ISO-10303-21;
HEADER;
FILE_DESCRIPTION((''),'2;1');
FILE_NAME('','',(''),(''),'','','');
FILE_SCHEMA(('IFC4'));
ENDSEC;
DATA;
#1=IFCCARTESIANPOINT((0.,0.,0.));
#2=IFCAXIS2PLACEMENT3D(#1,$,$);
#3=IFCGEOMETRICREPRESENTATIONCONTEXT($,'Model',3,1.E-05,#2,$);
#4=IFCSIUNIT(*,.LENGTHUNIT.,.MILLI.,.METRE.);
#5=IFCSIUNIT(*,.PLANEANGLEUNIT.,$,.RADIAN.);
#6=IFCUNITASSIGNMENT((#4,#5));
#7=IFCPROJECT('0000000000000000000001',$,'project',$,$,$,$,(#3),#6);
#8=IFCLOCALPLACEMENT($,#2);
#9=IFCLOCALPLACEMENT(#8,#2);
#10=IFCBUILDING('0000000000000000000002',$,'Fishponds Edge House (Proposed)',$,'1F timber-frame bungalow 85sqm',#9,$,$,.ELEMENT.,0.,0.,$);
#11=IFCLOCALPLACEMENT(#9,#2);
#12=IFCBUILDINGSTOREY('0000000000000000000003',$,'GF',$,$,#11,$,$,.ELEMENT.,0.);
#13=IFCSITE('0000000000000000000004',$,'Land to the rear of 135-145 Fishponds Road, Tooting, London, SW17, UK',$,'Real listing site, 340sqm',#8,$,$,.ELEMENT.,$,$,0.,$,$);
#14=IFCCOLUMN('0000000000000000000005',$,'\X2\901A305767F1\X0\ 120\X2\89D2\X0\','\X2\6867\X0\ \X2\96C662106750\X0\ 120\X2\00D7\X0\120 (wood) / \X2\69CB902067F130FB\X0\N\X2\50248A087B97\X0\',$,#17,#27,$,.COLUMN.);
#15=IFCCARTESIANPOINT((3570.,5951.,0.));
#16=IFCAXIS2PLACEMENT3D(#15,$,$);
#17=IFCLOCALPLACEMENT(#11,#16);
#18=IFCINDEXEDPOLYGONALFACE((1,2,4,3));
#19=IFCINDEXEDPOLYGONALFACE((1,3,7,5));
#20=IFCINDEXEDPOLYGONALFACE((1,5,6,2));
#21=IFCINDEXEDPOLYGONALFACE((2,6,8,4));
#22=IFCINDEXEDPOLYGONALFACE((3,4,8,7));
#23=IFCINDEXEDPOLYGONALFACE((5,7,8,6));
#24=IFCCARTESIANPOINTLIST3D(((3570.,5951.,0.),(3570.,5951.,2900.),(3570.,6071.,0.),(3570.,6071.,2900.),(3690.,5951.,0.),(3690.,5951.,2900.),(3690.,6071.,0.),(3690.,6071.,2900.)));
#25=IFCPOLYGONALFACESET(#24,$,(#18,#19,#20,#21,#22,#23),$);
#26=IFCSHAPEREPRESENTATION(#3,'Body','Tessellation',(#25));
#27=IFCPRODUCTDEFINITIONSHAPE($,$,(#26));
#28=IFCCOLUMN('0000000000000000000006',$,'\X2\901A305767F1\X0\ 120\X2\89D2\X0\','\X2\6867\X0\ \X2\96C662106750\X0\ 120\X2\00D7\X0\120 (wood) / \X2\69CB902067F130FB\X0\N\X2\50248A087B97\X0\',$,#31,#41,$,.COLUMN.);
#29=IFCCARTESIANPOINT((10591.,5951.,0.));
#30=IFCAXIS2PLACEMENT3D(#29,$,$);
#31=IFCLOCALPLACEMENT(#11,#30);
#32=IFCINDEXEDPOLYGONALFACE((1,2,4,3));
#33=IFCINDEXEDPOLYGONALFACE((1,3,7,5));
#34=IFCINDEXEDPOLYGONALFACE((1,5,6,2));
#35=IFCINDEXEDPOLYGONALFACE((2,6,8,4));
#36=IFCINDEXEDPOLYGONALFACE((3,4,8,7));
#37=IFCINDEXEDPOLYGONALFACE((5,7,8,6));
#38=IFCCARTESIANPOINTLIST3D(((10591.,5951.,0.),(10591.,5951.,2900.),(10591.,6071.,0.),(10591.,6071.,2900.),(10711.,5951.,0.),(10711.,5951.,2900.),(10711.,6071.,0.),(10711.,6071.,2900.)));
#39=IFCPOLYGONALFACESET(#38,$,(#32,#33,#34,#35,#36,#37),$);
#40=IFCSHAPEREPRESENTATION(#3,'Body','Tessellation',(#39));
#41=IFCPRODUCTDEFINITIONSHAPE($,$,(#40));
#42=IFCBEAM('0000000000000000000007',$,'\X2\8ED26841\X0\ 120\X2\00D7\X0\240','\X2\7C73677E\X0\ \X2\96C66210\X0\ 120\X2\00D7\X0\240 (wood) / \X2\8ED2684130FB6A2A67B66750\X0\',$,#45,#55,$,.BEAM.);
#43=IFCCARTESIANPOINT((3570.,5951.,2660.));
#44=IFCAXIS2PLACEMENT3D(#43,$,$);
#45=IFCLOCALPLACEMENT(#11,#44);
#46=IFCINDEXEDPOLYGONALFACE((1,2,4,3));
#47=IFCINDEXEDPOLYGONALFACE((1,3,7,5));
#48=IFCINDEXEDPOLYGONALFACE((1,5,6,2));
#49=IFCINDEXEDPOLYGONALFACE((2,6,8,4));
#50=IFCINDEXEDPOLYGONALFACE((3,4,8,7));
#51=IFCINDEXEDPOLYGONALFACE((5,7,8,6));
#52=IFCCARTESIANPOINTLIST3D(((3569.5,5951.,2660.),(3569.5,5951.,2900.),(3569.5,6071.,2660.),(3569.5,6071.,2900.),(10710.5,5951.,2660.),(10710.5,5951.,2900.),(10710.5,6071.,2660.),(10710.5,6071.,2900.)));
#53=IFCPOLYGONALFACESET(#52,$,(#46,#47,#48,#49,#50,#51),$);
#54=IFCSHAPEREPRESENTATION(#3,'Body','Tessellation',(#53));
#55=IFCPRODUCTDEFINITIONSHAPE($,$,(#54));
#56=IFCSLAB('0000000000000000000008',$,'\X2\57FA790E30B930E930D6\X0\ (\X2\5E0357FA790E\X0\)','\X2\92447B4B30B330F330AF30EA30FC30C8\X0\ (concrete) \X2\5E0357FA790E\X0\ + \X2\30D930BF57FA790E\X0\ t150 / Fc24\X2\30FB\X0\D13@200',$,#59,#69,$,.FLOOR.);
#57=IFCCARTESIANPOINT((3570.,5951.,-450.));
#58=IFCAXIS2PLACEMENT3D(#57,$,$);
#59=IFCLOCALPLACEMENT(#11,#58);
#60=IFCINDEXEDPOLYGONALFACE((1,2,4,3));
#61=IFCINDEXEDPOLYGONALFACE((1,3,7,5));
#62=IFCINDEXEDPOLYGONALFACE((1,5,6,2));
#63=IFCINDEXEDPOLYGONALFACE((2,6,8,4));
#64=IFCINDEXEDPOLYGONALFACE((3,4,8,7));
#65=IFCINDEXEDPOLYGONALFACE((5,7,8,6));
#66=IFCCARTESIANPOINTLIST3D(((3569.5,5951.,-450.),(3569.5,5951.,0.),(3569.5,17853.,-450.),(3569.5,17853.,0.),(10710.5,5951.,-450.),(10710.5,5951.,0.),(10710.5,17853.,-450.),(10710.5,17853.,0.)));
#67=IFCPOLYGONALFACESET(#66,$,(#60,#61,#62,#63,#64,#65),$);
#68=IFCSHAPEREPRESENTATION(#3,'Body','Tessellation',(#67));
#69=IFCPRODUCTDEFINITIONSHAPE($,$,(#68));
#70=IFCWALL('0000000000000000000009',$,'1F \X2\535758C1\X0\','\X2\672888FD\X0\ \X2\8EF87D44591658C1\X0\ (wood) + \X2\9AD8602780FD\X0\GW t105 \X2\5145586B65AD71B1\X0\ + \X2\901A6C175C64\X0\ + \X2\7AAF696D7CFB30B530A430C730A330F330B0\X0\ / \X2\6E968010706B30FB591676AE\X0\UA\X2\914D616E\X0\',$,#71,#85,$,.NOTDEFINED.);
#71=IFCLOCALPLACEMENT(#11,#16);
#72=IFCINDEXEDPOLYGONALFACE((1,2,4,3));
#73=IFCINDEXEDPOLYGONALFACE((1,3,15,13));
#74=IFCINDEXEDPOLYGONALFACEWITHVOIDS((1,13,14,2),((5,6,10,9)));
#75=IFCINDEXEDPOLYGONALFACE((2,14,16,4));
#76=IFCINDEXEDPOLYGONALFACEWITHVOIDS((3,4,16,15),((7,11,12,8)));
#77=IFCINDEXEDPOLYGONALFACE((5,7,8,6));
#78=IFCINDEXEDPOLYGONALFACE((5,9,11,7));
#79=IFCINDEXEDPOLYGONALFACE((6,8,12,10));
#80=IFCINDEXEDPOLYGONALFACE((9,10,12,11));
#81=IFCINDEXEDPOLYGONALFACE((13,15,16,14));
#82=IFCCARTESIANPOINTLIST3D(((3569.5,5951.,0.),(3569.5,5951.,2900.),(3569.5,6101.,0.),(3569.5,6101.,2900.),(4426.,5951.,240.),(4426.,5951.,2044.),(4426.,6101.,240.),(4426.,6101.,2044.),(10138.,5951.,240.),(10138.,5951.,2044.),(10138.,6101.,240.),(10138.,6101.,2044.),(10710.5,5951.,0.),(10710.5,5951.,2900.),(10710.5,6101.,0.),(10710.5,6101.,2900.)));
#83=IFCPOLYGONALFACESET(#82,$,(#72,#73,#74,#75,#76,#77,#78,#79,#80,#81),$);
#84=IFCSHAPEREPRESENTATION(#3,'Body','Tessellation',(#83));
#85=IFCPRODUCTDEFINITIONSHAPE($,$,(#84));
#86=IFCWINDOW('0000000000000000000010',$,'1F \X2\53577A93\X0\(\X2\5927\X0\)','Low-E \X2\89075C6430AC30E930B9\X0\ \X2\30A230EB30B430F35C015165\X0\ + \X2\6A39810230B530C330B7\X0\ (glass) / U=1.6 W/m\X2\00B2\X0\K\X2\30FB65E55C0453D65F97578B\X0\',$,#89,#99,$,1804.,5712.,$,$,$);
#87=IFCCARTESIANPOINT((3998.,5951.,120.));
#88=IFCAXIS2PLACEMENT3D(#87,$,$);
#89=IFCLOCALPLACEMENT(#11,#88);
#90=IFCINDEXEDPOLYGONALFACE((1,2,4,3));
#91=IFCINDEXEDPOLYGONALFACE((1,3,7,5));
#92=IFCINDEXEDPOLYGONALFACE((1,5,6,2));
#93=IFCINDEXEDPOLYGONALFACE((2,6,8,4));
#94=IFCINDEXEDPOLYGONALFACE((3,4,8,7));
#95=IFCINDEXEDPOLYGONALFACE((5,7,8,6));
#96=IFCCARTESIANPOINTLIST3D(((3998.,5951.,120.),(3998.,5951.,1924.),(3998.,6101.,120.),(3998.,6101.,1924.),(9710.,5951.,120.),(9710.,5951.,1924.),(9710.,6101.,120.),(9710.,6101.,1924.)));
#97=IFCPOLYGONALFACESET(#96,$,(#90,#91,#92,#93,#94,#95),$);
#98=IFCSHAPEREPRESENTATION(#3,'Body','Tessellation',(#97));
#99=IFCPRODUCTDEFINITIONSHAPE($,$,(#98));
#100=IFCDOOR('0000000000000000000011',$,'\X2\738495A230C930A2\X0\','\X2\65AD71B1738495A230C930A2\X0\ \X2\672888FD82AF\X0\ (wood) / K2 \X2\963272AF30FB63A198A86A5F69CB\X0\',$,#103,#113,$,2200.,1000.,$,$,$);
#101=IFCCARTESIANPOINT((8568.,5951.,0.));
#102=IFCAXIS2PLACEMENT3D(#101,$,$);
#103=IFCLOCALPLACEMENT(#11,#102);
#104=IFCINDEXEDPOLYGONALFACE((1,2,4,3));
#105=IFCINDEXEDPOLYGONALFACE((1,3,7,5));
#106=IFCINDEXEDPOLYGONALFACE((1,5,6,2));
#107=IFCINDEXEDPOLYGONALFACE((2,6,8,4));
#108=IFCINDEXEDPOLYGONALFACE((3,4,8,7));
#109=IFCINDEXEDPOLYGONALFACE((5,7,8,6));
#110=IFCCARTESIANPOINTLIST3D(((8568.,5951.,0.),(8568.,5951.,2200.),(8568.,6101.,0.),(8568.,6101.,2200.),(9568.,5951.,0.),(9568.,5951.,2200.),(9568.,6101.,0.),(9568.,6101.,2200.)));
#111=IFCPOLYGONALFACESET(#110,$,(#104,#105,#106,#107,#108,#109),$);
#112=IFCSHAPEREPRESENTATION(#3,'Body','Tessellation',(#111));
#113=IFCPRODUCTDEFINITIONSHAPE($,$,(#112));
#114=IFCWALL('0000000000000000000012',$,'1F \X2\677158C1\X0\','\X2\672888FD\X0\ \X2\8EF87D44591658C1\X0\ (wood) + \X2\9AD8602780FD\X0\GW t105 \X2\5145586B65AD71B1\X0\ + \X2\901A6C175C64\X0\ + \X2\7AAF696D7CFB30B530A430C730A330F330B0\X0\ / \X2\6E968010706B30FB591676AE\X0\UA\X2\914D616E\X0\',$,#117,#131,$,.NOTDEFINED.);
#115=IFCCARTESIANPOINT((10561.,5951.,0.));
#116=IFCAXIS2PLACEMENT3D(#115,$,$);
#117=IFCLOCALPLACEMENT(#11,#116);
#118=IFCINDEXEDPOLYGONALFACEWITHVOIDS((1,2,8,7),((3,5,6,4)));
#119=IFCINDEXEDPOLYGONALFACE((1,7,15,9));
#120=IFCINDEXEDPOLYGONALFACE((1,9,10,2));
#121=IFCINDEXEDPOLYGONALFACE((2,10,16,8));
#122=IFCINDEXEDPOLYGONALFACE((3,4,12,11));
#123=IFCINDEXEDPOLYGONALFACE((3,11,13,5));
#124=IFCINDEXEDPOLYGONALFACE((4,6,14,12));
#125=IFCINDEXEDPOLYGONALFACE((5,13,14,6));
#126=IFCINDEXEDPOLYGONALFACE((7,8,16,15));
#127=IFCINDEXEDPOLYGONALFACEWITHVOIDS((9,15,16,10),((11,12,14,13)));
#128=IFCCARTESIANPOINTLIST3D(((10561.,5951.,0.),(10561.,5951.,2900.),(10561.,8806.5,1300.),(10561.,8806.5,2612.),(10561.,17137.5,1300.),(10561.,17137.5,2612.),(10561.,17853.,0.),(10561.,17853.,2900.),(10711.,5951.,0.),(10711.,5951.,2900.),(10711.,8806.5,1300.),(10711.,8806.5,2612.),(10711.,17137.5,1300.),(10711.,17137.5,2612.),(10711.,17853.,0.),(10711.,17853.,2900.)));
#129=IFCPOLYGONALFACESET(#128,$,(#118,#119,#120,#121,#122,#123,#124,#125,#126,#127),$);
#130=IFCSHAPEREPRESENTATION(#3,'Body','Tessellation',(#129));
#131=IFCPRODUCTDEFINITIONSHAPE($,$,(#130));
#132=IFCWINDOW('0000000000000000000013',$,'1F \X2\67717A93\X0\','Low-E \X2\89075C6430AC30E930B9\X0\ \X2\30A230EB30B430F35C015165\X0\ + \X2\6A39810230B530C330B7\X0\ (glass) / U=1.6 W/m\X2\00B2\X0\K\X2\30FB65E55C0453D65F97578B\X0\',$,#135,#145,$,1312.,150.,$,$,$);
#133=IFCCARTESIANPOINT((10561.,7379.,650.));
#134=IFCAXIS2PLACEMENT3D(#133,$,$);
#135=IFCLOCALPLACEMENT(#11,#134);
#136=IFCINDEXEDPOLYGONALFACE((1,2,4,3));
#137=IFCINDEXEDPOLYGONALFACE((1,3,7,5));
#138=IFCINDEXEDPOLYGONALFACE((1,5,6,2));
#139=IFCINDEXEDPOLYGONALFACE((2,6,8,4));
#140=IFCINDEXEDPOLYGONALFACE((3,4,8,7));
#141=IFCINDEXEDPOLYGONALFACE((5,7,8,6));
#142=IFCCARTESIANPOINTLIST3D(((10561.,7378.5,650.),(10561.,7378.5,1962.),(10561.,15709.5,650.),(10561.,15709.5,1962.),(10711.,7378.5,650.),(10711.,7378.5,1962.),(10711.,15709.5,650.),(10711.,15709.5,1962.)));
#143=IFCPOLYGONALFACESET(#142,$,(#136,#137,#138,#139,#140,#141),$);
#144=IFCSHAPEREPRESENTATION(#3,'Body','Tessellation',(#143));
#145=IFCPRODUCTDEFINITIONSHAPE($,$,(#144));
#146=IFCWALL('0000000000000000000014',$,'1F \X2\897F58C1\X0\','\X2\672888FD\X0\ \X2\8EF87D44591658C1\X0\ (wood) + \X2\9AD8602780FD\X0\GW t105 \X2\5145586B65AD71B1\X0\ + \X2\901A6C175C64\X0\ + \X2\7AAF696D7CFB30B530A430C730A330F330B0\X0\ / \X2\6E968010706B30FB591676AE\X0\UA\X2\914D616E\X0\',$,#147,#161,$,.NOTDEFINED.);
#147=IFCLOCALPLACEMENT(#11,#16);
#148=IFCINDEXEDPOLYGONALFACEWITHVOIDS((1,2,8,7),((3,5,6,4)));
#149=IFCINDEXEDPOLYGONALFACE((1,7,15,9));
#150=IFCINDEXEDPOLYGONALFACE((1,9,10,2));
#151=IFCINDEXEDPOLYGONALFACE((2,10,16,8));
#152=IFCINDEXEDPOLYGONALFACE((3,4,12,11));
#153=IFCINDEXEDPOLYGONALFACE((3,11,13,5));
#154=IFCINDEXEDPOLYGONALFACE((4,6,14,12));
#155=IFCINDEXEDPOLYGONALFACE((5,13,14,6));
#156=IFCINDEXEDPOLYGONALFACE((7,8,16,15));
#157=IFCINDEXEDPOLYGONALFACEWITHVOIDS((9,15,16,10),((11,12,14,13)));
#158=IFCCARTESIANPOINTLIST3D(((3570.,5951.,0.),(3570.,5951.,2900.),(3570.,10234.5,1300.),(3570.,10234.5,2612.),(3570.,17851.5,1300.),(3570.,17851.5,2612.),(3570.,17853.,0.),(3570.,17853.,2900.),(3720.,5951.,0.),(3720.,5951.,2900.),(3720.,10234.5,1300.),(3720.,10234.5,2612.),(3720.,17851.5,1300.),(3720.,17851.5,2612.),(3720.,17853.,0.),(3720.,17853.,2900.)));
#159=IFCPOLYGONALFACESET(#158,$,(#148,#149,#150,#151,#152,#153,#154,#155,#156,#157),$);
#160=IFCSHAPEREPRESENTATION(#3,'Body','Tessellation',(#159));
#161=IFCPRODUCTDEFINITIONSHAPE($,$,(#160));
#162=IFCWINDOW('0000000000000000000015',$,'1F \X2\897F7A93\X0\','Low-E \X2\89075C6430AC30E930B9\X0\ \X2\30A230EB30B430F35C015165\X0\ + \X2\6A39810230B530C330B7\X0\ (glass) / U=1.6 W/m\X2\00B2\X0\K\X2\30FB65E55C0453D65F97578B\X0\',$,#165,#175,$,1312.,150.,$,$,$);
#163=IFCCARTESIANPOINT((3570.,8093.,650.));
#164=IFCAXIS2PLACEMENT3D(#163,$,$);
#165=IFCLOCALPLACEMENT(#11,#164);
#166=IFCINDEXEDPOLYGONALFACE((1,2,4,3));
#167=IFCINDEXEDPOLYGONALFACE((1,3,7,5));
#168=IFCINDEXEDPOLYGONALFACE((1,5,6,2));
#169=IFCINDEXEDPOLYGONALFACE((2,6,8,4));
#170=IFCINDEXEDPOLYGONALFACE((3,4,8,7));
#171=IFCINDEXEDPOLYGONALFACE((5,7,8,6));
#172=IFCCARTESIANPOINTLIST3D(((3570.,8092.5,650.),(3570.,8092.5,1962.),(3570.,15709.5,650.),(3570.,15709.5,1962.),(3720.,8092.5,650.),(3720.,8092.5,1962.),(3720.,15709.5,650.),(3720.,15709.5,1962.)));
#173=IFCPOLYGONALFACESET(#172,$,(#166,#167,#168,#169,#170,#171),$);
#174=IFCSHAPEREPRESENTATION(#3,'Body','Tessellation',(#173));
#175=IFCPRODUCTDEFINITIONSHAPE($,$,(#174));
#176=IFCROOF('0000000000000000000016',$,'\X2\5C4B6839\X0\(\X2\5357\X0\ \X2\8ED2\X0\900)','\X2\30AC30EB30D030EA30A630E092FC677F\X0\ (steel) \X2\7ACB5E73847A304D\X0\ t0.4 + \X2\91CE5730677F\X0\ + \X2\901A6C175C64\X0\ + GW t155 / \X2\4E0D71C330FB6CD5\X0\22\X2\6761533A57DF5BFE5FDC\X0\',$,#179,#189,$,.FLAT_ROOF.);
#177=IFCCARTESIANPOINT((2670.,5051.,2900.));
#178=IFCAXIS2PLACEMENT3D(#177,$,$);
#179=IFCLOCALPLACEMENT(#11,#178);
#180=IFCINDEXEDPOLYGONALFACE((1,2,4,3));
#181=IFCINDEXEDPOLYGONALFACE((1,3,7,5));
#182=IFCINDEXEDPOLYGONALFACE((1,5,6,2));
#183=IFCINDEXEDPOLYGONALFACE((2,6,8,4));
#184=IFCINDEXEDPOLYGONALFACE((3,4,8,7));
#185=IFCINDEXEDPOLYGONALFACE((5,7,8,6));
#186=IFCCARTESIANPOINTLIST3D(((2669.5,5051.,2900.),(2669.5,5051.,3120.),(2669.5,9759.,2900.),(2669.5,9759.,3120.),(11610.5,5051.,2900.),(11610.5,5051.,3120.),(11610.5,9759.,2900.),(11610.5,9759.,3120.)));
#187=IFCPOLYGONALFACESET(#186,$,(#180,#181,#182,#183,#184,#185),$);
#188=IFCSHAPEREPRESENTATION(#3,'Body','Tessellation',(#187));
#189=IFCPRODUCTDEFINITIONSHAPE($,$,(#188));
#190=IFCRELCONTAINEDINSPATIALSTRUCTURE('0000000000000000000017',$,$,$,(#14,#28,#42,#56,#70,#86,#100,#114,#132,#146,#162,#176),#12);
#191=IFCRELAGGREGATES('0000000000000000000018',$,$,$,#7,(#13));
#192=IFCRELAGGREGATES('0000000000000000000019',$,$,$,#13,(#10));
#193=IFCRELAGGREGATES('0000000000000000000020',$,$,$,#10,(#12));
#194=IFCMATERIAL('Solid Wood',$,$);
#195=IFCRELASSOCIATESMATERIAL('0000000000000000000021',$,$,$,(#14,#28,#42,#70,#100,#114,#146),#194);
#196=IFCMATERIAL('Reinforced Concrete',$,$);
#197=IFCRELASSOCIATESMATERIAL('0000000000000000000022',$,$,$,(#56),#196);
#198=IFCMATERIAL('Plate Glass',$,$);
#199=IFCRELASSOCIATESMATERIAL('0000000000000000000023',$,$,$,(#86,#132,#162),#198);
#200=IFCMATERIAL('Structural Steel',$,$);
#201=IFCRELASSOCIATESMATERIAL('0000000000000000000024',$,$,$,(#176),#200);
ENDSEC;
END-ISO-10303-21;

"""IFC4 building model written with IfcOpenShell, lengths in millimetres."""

from ifc_helpers import new_model, si_unit, frame, frame_2d, origin, place, context, project, spatial, rectangle, extrude, material, element, fill, save


model = new_model("IFC4")

# Units and contexts
model_context = context("Model", 3, precision=1e-05, world=origin())
ifc_project = project(units=[si_unit("LENGTHUNIT", "METRE", prefix="MILLI"), si_unit("PLANEANGLEUNIT", "RADIAN")], contexts=[model_context])

# Site, building, storey
site_placement = place(None, origin())
site = spatial("IfcSite", under=ifc_project, at=site_placement, Name="Land to the rear of 135-145 Fishponds Road, Tooting, London, SW17, UK", ObjectType="Real listing site, 340sqm", CompositionType="ELEMENT", RefElevation=0.0)
building_placement = place(site_placement, origin())
building = spatial("IfcBuilding", under=site, at=building_placement, Name="Fishponds Edge House (Proposed)", ObjectType="1F timber-frame bungalow 85sqm", CompositionType="ELEMENT", ElevationOfRefHeight=0.0, ElevationOfTerrain=0.0)
storey_placement = place(building_placement, origin())
storey = spatial("IfcBuildingStorey", under=building, at=storey_placement, Name="GF", CompositionType="ELEMENT", Elevation=0.0)

# Columns
ifc_material_1 = material(Name="Solid Wood")
column_1_placement = place(storey_placement, frame((3570.0, 5951.0, 0.0)))
element("IfcColumn", 1, at=column_1_placement, inside=storey, material=ifc_material_1, Name="通し柱 120角", Description="桧 集成材 120×120 (wood) / 構造柱・N値計算", PredefinedType="COLUMN", context=model_context, shape_type="SweptSolid", body=[
    extrude(rectangle(XDim=120.0, YDim=120.0, at=frame_2d((60.0, 60.0))), frame((3570.0, 5951.0, 0.0)), (0.0, 0.0, 1.0), 2900.0),
])
column_2_placement = place(storey_placement, frame((10591.0, 5951.0, 0.0)))
element("IfcColumn", 2, at=column_2_placement, inside=storey, material=ifc_material_1, Name="通し柱 120角", Description="桧 集成材 120×120 (wood) / 構造柱・N値計算", PredefinedType="COLUMN", context=model_context, shape_type="SweptSolid", body=[
    extrude(rectangle(XDim=120.0, YDim=120.0, at=frame_2d((60.0, 60.0))), frame((10591.0, 5951.0, 0.0)), (0.0, 0.0, 1.0), 2900.0),
])

# Beam
beam_1_placement = place(storey_placement, frame((3570.0, 5951.0, 2660.0)))
element("IfcBeam", 3, at=beam_1_placement, inside=storey, material=ifc_material_1, Name="軒桁 120×240", Description="米松 集成 120×240 (wood) / 軒桁・横架材", PredefinedType="BEAM", context=model_context, shape_type="SweptSolid", body=[
    extrude(rectangle(XDim=7141.0, YDim=120.0, at=frame_2d((3570.0, 60.0))), frame((3570.0, 5951.0, 2660.0)), (0.0, 0.0, 1.0), 240.0),
])

# Slab
ifc_material_2 = material(Name="Reinforced Concrete")
slab_1_placement = place(storey_placement, frame((3570.0, 5951.0, -450.0)))
element("IfcSlab", 4, at=slab_1_placement, inside=storey, material=ifc_material_2, Name="基礎スラブ (布基礎)", Description="鉄筋コンクリート (concrete) 布基礎 + ベタ基礎 t150 / Fc24・D13@200", PredefinedType="FLOOR", context=model_context, shape_type="SweptSolid", body=[
    extrude(rectangle(XDim=7141.0, YDim=11902.0, at=frame_2d((3570.0, 5951.0))), frame((3570.0, 5951.0, -450.0)), (0.0, 0.0, 1.0), 450.0),
])

# Wall, openings, window, door
wall_1_placement = place(storey_placement, frame((3570.0, 5951.0, 0.0)))
wall_1 = element("IfcWall", 5, at=wall_1_placement, inside=storey, material=ifc_material_1, Name="1F 南壁", Description="木製 軸組外壁 (wood) + 高性能GW t105 充填断熱 + 通気層 + 窯業系サイディング / 準耐火・外皮UA配慮", PredefinedType="NOTDEFINED", context=model_context, shape_type="SweptSolid", body=[
    extrude(rectangle(XDim=7141.0, YDim=150.0, at=frame_2d((3570.0, 75.0))), frame((3570.0, 5951.0, 0.0)), (0.0, 0.0, 1.0), 2900.0),
])
opening_1_placement = place(storey_placement, frame((3998.0, 5951.0, 120.0)))
opening_1 = element("IfcOpeningElement", 6, at=opening_1_placement, cuts=wall_1, PredefinedType="NOTDEFINED", context=model_context, shape_type="SweptSolid", body=[
    extrude(rectangle(XDim=5712.0, YDim=150.0, at=frame_2d((2856.0, 75.0))), frame((3998.0, 5951.0, 120.0)), (0.0, 0.0, 1.0), 1804.0),
])
opening_2_placement = place(storey_placement, frame((8568.0, 5951.0, 0.0)))
opening_2 = element("IfcOpeningElement", 7, at=opening_2_placement, cuts=wall_1, PredefinedType="NOTDEFINED", context=model_context, shape_type="SweptSolid", body=[
    extrude(rectangle(XDim=1000.0, YDim=150.0, at=frame_2d((500.0, 75.0))), frame((8568.0, 5951.0, 0.0)), (0.0, 0.0, 1.0), 2200.0),
])
ifc_material_3 = material(Name="Plate Glass")
window_1_placement = place(storey_placement, frame((3998.0, 5951.0, 120.0)))
window_1 = element("IfcWindow", 8, at=window_1_placement, inside=storey, material=ifc_material_3, Name="1F 南窓(大)", Description="Low-E 複層ガラス アルゴン封入 + 樹脂サッシ (glass) / U=1.6 W/m²K・日射取得型", OverallHeight=1804.0, OverallWidth=5712.0, context=model_context, shape_type="SweptSolid", body=[
    extrude(rectangle(XDim=5712.0, YDim=150.0, at=frame_2d((2856.0, 75.0))), frame((3998.0, 5951.0, 120.0)), (0.0, 0.0, 1.0), 1804.0),
])
fill(opening_1, window_1)
door_placement = place(storey_placement, frame((8568.0, 5951.0, 0.0)))
door = element("IfcDoor", 9, at=door_placement, inside=storey, material=ifc_material_1, Name="玄関ドア", Description="断熱玄関ドア 木製芯 (wood) / K2 防犯・採風機構", OverallHeight=2200.0, OverallWidth=1000.0, context=model_context, shape_type="SweptSolid", body=[
    extrude(rectangle(XDim=1000.0, YDim=150.0, at=frame_2d((500.0, 75.0))), frame((8568.0, 5951.0, 0.0)), (0.0, 0.0, 1.0), 2200.0),
])
fill(opening_2, door)

# Walls, openings, windows
wall_2_placement = place(storey_placement, frame((10561.0, 5951.0, 0.0)))
wall_2 = element("IfcWall", 10, at=wall_2_placement, inside=storey, material=ifc_material_1, Name="1F 東壁", Description="木製 軸組外壁 (wood) + 高性能GW t105 充填断熱 + 通気層 + 窯業系サイディング / 準耐火・外皮UA配慮", PredefinedType="NOTDEFINED", context=model_context, shape_type="SweptSolid", body=[
    extrude(rectangle(XDim=150.0, YDim=11902.0, at=frame_2d((75.0, 5951.0))), frame((10561.0, 5951.0, 0.0)), (0.0, 0.0, 1.0), 2900.0),
])
opening_3_placement = place(storey_placement, frame((10561.0, 7379.0, 650.0)))
opening_3 = element("IfcOpeningElement", 11, at=opening_3_placement, cuts=wall_2, PredefinedType="NOTDEFINED", context=model_context, shape_type="SweptSolid", body=[
    extrude(rectangle(XDim=150.0, YDim=8331.0, at=frame_2d((75.0, 4165.0))), frame((10561.0, 7379.0, 650.0)), (0.0, 0.0, 1.0), 1312.0),
])
window_2_placement = place(storey_placement, frame((10561.0, 7379.0, 650.0)))
window_2 = element("IfcWindow", 12, at=window_2_placement, inside=storey, material=ifc_material_3, Name="1F 東窓", Description="Low-E 複層ガラス アルゴン封入 + 樹脂サッシ (glass) / U=1.6 W/m²K・日射取得型", OverallHeight=1312.0, OverallWidth=150.0, context=model_context, shape_type="SweptSolid", body=[
    extrude(rectangle(XDim=150.0, YDim=8331.0, at=frame_2d((75.0, 4165.0))), frame((10561.0, 7379.0, 650.0)), (0.0, 0.0, 1.0), 1312.0),
])
fill(opening_3, window_2)
wall_3_placement = place(storey_placement, frame((3570.0, 5951.0, 0.0)))
wall_3 = element("IfcWall", 13, at=wall_3_placement, inside=storey, material=ifc_material_1, Name="1F 西壁", Description="木製 軸組外壁 (wood) + 高性能GW t105 充填断熱 + 通気層 + 窯業系サイディング / 準耐火・外皮UA配慮", PredefinedType="NOTDEFINED", context=model_context, shape_type="SweptSolid", body=[
    extrude(rectangle(XDim=150.0, YDim=11902.0, at=frame_2d((75.0, 5951.0))), frame((3570.0, 5951.0, 0.0)), (0.0, 0.0, 1.0), 2900.0),
])
opening_4_placement = place(storey_placement, frame((3570.0, 8093.0, 650.0)))
opening_4 = element("IfcOpeningElement", 14, at=opening_4_placement, cuts=wall_3, PredefinedType="NOTDEFINED", context=model_context, shape_type="SweptSolid", body=[
    extrude(rectangle(XDim=150.0, YDim=7617.0, at=frame_2d((75.0, 3808.0))), frame((3570.0, 8093.0, 650.0)), (0.0, 0.0, 1.0), 1312.0),
])
window_3_placement = place(storey_placement, frame((3570.0, 8093.0, 650.0)))
window_3 = element("IfcWindow", 15, at=window_3_placement, inside=storey, material=ifc_material_3, Name="1F 西窓", Description="Low-E 複層ガラス アルゴン封入 + 樹脂サッシ (glass) / U=1.6 W/m²K・日射取得型", OverallHeight=1312.0, OverallWidth=150.0, context=model_context, shape_type="SweptSolid", body=[
    extrude(rectangle(XDim=150.0, YDim=7617.0, at=frame_2d((75.0, 3808.0))), frame((3570.0, 8093.0, 650.0)), (0.0, 0.0, 1.0), 1312.0),
])
fill(opening_4, window_3)

# Roof
ifc_material_4 = material(Name="Structural Steel")
roof_placement = place(storey_placement, frame((2670.0, 5051.0, 2900.0)))
element("IfcRoof", 16, at=roof_placement, inside=storey, material=ifc_material_4, Name="屋根(南 軒900)", Description="ガルバリウム鋼板 (steel) 立平葺き t0.4 + 野地板 + 通気層 + GW t155 / 不燃・法22条区域対応", PredefinedType="FLAT_ROOF", context=model_context, shape_type="SweptSolid", body=[
    extrude(rectangle(XDim=8941.0, YDim=4708.0, at=frame_2d((4470.0, 2354.0))), frame((2670.0, 5051.0, 2900.0)), (0.0, 0.0, 1.0), 220.0),
])

save(model, "model.ifc")
